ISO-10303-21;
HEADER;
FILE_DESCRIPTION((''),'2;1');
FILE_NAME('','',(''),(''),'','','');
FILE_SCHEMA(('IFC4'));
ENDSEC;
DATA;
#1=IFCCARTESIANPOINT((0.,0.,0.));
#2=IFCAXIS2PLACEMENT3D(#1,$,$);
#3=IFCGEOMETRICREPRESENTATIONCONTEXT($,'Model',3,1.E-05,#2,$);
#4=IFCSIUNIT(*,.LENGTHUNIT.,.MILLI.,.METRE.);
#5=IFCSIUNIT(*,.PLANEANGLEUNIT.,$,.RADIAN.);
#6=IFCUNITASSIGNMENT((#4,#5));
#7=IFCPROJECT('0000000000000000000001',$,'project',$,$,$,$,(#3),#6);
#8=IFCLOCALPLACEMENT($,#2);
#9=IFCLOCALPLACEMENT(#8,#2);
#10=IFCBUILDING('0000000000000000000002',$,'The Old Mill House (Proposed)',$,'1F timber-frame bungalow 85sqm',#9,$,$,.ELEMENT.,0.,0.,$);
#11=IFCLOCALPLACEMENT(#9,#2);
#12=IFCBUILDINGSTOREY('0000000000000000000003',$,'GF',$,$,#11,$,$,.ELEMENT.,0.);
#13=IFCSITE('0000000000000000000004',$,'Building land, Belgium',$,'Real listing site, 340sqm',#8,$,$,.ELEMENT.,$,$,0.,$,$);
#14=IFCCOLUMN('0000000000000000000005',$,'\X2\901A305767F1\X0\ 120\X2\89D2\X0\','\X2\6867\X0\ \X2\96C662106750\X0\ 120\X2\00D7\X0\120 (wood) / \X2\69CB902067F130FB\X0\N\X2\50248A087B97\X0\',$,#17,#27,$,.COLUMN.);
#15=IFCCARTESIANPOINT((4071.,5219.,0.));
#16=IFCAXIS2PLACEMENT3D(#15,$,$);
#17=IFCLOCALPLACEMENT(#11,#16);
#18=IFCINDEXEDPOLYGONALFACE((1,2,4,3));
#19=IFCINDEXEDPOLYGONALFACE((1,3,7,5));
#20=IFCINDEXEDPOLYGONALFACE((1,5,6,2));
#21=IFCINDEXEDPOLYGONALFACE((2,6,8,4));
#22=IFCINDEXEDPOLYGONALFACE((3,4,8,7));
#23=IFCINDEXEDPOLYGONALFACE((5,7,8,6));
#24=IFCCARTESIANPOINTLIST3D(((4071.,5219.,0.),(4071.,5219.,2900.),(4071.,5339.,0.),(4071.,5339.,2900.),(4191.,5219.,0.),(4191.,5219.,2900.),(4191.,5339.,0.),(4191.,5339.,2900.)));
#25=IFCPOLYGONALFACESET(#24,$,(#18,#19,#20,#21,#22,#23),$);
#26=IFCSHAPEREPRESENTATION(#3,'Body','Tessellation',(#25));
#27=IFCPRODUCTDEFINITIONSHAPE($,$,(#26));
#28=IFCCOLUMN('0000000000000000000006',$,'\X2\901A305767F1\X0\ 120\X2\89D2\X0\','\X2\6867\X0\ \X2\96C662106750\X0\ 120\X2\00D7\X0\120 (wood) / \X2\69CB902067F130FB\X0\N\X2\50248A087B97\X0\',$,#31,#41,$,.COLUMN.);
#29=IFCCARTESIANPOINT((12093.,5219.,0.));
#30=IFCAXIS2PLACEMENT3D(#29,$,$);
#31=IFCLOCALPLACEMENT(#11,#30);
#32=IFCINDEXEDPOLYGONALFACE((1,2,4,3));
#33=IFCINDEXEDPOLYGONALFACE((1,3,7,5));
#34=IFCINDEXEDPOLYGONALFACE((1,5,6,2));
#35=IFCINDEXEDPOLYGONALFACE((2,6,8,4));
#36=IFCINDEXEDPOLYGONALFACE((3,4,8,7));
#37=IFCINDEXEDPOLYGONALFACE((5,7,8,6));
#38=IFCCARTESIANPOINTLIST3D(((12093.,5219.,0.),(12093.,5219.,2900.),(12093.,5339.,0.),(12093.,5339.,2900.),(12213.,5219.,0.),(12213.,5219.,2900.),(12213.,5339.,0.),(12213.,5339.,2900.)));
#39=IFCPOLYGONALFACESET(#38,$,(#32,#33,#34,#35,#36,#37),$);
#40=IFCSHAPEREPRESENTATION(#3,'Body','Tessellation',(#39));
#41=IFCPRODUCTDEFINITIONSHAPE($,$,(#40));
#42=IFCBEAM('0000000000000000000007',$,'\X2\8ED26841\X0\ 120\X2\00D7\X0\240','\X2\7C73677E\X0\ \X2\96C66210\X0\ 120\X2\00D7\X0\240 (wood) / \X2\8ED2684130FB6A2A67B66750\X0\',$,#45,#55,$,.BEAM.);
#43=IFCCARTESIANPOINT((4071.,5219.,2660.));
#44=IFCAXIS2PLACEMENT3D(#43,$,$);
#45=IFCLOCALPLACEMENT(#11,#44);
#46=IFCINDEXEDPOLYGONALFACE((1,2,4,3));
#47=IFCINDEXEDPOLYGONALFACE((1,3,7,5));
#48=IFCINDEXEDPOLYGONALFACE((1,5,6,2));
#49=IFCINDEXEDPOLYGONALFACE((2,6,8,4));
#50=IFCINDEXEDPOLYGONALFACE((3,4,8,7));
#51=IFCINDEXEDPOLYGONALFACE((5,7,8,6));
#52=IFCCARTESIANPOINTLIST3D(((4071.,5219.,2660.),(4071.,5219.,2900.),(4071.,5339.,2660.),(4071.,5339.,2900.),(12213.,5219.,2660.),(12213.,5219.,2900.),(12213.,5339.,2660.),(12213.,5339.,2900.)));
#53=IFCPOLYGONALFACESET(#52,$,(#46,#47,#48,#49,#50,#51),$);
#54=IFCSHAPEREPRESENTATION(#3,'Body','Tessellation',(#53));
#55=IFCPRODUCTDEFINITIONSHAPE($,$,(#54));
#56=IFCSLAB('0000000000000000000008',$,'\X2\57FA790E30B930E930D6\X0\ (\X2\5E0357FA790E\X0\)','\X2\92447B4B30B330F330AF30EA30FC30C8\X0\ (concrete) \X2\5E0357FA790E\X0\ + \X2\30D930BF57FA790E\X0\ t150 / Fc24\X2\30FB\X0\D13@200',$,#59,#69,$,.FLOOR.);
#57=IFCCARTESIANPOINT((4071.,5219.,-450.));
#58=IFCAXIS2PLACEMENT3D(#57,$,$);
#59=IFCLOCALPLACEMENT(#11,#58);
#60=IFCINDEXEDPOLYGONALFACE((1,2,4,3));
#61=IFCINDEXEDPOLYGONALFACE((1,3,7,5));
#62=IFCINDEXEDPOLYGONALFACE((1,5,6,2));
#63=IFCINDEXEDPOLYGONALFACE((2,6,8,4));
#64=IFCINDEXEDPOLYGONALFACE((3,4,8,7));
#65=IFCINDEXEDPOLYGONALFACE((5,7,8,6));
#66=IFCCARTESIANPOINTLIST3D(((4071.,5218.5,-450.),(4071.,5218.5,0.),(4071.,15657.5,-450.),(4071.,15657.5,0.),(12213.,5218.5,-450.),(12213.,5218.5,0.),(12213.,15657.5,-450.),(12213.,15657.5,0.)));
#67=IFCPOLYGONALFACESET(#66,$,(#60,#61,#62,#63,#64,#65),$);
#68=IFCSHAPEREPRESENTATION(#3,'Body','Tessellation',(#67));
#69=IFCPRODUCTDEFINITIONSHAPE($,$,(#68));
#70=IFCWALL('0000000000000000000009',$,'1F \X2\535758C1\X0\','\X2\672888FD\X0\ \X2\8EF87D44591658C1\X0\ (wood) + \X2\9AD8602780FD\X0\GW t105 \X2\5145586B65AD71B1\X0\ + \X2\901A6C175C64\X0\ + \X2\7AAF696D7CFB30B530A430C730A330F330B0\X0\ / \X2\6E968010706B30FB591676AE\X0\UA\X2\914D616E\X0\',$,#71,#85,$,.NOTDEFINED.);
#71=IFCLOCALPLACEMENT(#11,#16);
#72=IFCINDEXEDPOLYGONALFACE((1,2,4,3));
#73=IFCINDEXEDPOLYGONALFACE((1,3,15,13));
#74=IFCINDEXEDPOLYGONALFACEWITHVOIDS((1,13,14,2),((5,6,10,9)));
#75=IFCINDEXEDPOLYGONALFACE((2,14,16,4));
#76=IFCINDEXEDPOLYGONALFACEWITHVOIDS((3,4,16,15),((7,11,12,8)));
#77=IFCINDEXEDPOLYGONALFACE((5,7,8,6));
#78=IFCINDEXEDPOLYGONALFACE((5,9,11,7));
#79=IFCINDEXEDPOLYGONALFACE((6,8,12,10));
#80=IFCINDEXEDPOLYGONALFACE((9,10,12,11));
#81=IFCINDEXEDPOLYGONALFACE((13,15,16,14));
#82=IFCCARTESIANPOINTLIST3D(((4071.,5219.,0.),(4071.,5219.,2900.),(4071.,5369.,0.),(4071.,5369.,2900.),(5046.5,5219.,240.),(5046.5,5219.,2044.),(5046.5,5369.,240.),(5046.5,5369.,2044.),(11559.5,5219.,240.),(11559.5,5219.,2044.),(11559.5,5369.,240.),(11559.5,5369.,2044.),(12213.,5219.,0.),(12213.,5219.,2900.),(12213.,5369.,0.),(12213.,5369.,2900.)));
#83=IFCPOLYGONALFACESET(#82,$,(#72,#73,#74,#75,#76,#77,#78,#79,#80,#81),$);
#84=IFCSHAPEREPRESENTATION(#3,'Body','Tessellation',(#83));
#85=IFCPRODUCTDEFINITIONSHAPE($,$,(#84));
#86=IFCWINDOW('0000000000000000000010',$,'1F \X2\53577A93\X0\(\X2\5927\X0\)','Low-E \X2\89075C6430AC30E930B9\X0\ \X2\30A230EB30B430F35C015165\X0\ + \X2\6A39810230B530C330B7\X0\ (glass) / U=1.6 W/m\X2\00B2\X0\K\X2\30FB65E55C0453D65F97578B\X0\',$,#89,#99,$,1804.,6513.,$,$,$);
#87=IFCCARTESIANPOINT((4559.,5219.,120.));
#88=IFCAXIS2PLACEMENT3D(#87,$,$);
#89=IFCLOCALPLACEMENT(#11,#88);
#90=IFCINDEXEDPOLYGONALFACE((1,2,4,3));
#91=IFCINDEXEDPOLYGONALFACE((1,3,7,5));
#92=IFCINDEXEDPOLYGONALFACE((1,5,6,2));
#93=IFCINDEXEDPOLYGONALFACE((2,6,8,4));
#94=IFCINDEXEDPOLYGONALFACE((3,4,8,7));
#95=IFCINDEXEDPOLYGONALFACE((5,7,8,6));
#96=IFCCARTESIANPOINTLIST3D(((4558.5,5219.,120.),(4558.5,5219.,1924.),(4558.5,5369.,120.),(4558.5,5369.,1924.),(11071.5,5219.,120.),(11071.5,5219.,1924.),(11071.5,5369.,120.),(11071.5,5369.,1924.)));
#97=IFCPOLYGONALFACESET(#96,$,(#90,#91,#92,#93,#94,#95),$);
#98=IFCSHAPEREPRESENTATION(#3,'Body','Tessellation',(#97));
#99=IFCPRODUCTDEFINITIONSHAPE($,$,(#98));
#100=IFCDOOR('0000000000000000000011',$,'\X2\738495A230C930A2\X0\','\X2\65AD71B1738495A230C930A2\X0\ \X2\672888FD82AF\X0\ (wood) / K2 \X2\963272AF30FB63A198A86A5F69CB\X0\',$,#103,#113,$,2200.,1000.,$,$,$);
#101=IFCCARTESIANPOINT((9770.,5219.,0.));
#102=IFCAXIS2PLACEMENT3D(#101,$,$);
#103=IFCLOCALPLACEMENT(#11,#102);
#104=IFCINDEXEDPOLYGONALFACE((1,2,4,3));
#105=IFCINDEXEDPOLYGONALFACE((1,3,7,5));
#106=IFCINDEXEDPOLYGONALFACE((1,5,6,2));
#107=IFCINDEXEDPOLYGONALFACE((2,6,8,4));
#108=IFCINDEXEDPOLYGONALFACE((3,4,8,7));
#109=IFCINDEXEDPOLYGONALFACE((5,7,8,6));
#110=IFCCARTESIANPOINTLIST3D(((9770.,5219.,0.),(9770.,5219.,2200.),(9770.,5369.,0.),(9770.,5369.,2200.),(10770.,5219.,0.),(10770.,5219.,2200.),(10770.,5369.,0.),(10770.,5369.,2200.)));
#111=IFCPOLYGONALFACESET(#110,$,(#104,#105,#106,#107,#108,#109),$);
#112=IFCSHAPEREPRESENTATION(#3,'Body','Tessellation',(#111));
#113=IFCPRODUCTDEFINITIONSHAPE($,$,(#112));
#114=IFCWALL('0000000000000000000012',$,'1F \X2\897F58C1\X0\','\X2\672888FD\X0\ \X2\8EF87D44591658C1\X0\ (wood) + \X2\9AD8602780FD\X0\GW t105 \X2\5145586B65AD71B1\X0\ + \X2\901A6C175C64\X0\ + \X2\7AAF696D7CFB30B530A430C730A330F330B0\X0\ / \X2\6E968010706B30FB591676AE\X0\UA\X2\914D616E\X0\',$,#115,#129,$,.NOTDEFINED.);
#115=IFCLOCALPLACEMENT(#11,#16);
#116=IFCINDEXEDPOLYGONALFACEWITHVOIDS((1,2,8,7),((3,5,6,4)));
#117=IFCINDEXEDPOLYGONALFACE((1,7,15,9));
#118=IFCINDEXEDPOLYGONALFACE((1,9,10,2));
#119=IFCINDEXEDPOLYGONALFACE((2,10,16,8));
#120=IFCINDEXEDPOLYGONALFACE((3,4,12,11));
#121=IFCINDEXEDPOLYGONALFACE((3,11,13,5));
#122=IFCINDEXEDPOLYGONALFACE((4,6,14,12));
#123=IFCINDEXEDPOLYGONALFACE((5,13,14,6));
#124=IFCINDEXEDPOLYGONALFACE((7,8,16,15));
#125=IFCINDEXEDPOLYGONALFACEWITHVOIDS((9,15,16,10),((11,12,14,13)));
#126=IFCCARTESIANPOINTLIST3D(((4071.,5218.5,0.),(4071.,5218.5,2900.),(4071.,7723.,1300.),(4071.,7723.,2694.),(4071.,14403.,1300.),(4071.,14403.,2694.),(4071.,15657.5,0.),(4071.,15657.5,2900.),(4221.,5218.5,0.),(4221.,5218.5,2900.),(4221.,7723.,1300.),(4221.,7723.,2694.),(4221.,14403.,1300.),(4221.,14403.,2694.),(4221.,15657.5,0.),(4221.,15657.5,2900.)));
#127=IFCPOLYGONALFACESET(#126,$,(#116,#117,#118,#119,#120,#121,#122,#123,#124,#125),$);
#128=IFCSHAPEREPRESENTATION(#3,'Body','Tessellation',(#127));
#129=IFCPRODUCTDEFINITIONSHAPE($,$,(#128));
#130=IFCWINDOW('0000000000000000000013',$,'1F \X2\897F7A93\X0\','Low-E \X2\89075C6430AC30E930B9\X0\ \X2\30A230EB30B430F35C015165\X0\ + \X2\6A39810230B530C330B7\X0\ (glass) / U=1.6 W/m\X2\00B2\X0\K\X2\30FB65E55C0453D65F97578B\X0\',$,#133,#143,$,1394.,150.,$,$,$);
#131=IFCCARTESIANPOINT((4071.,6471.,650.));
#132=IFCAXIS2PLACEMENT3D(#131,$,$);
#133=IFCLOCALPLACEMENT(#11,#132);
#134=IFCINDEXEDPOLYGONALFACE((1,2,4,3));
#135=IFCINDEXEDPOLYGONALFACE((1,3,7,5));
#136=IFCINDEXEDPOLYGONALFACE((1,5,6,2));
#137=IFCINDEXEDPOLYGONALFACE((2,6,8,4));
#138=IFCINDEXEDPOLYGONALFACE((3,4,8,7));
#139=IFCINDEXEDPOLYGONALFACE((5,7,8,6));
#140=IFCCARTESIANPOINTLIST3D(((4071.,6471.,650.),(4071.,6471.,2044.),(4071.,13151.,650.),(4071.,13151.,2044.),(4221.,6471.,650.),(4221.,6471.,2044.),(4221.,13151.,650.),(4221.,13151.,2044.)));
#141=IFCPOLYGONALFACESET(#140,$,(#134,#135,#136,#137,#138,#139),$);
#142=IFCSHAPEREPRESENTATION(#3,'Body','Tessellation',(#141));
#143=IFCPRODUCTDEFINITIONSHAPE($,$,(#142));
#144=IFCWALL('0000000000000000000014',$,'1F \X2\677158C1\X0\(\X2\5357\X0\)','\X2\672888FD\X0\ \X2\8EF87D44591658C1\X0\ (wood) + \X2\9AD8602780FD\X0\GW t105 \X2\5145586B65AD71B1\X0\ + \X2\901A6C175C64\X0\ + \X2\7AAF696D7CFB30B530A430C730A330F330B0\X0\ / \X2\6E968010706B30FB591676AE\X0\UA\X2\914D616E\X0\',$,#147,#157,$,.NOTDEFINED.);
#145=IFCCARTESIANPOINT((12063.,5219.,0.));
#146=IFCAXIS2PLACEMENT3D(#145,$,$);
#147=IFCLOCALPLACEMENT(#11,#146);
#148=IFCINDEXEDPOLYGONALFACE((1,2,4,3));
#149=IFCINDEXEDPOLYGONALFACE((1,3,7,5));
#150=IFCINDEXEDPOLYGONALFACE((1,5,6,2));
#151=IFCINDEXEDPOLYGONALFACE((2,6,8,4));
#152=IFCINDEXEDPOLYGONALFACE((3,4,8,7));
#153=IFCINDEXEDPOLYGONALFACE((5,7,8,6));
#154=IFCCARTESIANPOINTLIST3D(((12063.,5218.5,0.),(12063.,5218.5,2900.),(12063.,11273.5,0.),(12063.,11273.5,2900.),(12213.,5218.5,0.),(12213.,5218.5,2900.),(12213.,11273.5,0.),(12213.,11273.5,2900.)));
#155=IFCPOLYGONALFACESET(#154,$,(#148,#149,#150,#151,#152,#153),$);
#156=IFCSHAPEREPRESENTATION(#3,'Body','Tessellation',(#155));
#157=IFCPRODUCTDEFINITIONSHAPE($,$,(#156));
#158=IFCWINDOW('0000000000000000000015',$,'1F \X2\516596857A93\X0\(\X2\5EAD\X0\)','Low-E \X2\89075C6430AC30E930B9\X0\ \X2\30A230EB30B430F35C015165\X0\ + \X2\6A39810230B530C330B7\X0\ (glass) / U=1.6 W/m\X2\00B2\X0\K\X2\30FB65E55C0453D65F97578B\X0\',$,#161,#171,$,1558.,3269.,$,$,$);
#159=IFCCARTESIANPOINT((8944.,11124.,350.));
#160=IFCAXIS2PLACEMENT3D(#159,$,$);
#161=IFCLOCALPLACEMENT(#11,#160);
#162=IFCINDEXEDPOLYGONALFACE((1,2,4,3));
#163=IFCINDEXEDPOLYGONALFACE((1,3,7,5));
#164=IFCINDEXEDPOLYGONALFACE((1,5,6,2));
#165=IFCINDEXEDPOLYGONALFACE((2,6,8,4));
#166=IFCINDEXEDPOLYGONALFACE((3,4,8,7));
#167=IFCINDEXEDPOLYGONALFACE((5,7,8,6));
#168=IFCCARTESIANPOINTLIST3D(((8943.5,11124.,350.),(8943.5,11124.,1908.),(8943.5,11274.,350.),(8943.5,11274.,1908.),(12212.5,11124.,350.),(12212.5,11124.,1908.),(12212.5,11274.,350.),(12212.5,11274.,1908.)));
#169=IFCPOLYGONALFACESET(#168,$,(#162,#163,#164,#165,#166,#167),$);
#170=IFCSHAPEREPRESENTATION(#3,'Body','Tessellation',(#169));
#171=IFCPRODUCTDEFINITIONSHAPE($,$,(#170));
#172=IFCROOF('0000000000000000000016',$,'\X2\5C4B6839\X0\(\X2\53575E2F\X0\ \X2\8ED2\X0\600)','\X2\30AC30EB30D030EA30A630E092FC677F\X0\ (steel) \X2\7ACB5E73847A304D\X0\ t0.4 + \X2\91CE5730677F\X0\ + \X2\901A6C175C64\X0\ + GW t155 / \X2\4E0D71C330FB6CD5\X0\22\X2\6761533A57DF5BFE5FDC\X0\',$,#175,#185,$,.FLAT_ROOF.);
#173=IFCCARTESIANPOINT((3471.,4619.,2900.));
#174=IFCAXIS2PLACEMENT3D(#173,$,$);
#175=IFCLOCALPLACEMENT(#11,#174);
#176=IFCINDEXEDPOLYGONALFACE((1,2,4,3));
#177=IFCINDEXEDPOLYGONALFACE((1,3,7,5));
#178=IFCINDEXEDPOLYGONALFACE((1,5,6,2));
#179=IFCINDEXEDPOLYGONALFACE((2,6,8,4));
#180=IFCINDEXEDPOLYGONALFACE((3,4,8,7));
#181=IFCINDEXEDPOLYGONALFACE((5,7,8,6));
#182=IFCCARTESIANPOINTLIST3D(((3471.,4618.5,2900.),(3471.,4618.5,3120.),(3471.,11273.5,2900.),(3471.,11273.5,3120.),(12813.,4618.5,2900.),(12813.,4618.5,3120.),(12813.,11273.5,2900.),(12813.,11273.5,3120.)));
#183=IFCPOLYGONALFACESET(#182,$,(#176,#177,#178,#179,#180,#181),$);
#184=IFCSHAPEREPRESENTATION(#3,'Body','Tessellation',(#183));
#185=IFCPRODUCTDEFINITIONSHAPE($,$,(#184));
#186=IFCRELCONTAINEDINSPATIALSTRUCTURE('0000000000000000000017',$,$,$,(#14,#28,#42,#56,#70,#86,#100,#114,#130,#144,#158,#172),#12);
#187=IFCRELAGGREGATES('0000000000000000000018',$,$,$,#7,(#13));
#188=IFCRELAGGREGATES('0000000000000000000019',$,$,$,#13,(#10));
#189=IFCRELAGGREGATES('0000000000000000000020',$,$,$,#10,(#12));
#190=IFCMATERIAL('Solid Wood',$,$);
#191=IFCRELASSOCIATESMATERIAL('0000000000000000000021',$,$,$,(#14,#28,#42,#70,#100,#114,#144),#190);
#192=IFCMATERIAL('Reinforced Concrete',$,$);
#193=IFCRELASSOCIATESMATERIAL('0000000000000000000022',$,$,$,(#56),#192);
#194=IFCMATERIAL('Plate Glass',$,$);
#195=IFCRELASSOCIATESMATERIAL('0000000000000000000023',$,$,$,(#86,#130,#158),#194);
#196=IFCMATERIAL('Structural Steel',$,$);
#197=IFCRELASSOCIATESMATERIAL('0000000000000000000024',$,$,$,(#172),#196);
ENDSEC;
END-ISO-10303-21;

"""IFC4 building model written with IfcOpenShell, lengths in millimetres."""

from ifc_helpers import new_model, si_unit, frame, frame_2d, origin, place, context, project, spatial, rectangle, extrude, material, element, fill, save


model = new_model("IFC4")

# Units and contexts
model_context = context("Model", 3, precision=1e-05, world=origin())
ifc_project = project(units=[si_unit("LENGTHUNIT", "METRE", prefix="MILLI"), si_unit("PLANEANGLEUNIT", "RADIAN")], contexts=[model_context])

# Site, building, storey
site_placement = place(None, origin())
site = spatial("IfcSite", under=ifc_project, at=site_placement, Name="Building land, Belgium", ObjectType="Real listing site, 340sqm", CompositionType="ELEMENT", RefElevation=0.0)
building_placement = place(site_placement, origin())
building = spatial("IfcBuilding", under=site, at=building_placement, Name="The Old Mill House (Proposed)", ObjectType="1F timber-frame bungalow 85sqm", CompositionType="ELEMENT", ElevationOfRefHeight=0.0, ElevationOfTerrain=0.0)
storey_placement = place(building_placement, origin())
storey = spatial("IfcBuildingStorey", under=building, at=storey_placement, Name="GF", CompositionType="ELEMENT", Elevation=0.0)

# Columns
ifc_material_1 = material(Name="Solid Wood")
column_1_placement = place(storey_placement, frame((4071.0, 5219.0, 0.0)))
element("IfcColumn", 1, at=column_1_placement, inside=storey, material=ifc_material_1, Name="通し柱 120角", Description="桧 集成材 120×120 (wood) / 構造柱・N値計算", PredefinedType="COLUMN", context=model_context, shape_type="SweptSolid", body=[
    extrude(rectangle(XDim=120.0, YDim=120.0, at=frame_2d((60.0, 60.0))), frame((4071.0, 5219.0, 0.0)), (0.0, 0.0, 1.0), 2900.0),
])
column_2_placement = place(storey_placement, frame((12093.0, 5219.0, 0.0)))
element("IfcColumn", 2, at=column_2_placement, inside=storey, material=ifc_material_1, Name="通し柱 120角", Description="桧 集成材 120×120 (wood) / 構造柱・N値計算", PredefinedType="COLUMN", context=model_context, shape_type="SweptSolid", body=[
    extrude(rectangle(XDim=120.0, YDim=120.0, at=frame_2d((60.0, 60.0))), frame((12093.0, 5219.0, 0.0)), (0.0, 0.0, 1.0), 2900.0),
])

# Beam
beam_1_placement = place(storey_placement, frame((4071.0, 5219.0, 2660.0)))
element("IfcBeam", 3, at=beam_1_placement, inside=storey, material=ifc_material_1, Name="軒桁 120×240", Description="米松 集成 120×240 (wood) / 軒桁・横架材", PredefinedType="BEAM", context=model_context, shape_type="SweptSolid", body=[
    extrude(rectangle(XDim=8142.0, YDim=120.0, at=frame_2d((4071.0, 60.0))), frame((4071.0, 5219.0, 2660.0)), (0.0, 0.0, 1.0), 240.0),
])

# Slab
ifc_material_2 = material(Name="Reinforced Concrete")
slab_1_placement = place(storey_placement, frame((4071.0, 5219.0, -450.0)))
element("IfcSlab", 4, at=slab_1_placement, inside=storey, material=ifc_material_2, Name="基礎スラブ (布基礎)", Description="鉄筋コンクリート (concrete) 布基礎 + ベタ基礎 t150 / Fc24・D13@200", PredefinedType="FLOOR", context=model_context, shape_type="SweptSolid", body=[
    extrude(rectangle(XDim=8142.0, YDim=10439.0, at=frame_2d((4071.0, 5219.0))), frame((4071.0, 5219.0, -450.0)), (0.0, 0.0, 1.0), 450.0),
])

# Wall, openings, window, door
wall_1_placement = place(storey_placement, frame((4071.0, 5219.0, 0.0)))
wall_1 = element("IfcWall", 5, at=wall_1_placement, inside=storey, material=ifc_material_1, Name="1F 南壁", Description="木製 軸組外壁 (wood) + 高性能GW t105 充填断熱 + 通気層 + 窯業系サイディング / 準耐火・外皮UA配慮", PredefinedType="NOTDEFINED", context=model_context, shape_type="SweptSolid", body=[
    extrude(rectangle(XDim=8142.0, YDim=150.0, at=frame_2d((4071.0, 75.0))), frame((4071.0, 5219.0, 0.0)), (0.0, 0.0, 1.0), 2900.0),
])
opening_1_placement = place(storey_placement, frame((4559.0, 5219.0, 120.0)))
opening_1 = element("IfcOpeningElement", 6, at=opening_1_placement, cuts=wall_1, PredefinedType="NOTDEFINED", context=model_context, shape_type="SweptSolid", body=[
    extrude(rectangle(XDim=6513.0, YDim=150.0, at=frame_2d((3256.0, 75.0))), frame((4559.0, 5219.0, 120.0)), (0.0, 0.0, 1.0), 1804.0),
])
opening_2_placement = place(storey_placement, frame((9770.0, 5219.0, 0.0)))
opening_2 = element("IfcOpeningElement", 7, at=opening_2_placement, cuts=wall_1, PredefinedType="NOTDEFINED", context=model_context, shape_type="SweptSolid", body=[
    extrude(rectangle(XDim=1000.0, YDim=150.0, at=frame_2d((500.0, 75.0))), frame((9770.0, 5219.0, 0.0)), (0.0, 0.0, 1.0), 2200.0),
])
ifc_material_3 = material(Name="Plate Glass")
window_1_placement = place(storey_placement, frame((4559.0, 5219.0, 120.0)))
window_1 = element("IfcWindow", 8, at=window_1_placement, inside=storey, material=ifc_material_3, Name="1F 南窓(大)", Description="Low-E 複層ガラス アルゴン封入 + 樹脂サッシ (glass) / U=1.6 W/m²K・日射取得型", OverallHeight=1804.0, OverallWidth=6513.0, context=model_context, shape_type="SweptSolid", body=[
    extrude(rectangle(XDim=6513.0, YDim=150.0, at=frame_2d((3256.0, 75.0))), frame((4559.0, 5219.0, 120.0)), (0.0, 0.0, 1.0), 1804.0),
])
fill(opening_1, window_1)
door_1_placement = place(storey_placement, frame((9770.0, 5219.0, 0.0)))
door_1 = element("IfcDoor", 9, at=door_1_placement, inside=storey, material=ifc_material_1, Name="玄関ドア", Description="断熱玄関ドア 木製芯 (wood) / K2 防犯・採風機構", OverallHeight=2200.0, OverallWidth=1000.0, context=model_context, shape_type="SweptSolid", body=[
    extrude(rectangle(XDim=1000.0, YDim=150.0, at=frame_2d((500.0, 75.0))), frame((9770.0, 5219.0, 0.0)), (0.0, 0.0, 1.0), 2200.0),
])
fill(opening_2, door_1)

# Walls, openings, windows
wall_2_placement = place(storey_placement, frame((4071.0, 5219.0, 0.0)))
wall_2 = element("IfcWall", 10, at=wall_2_placement, inside=storey, material=ifc_material_1, Name="1F 西壁", Description="木製 軸組外壁 (wood) + 高性能GW t105 充填断熱 + 通気層 + 窯業系サイディング / 準耐火・外皮UA配慮", PredefinedType="NOTDEFINED", context=model_context, shape_type="SweptSolid", body=[
    extrude(rectangle(XDim=150.0, YDim=10439.0, at=frame_2d((75.0, 5219.0))), frame((4071.0, 5219.0, 0.0)), (0.0, 0.0, 1.0), 2900.0),
])
opening_3_placement = place(storey_placement, frame((4071.0, 6471.0, 650.0)))
opening_3 = element("IfcOpeningElement", 11, at=opening_3_placement, cuts=wall_2, PredefinedType="NOTDEFINED", context=model_context, shape_type="SweptSolid", body=[
    extrude(rectangle(XDim=150.0, YDim=6680.0, at=frame_2d((75.0, 3340.0))), frame((4071.0, 6471.0, 650.0)), (0.0, 0.0, 1.0), 1394.0),
])
window_2_placement = place(storey_placement, frame((4071.0, 6471.0, 650.0)))
window_2 = element("IfcWindow", 12, at=window_2_placement, inside=storey, material=ifc_material_3, Name="1F 西窓", Description="Low-E 複層ガラス アルゴン封入 + 樹脂サッシ (glass) / U=1.6 W/m²K・日射取得型", OverallHeight=1394.0, OverallWidth=150.0, context=model_context, shape_type="SweptSolid", body=[
    extrude(rectangle(XDim=150.0, YDim=6680.0, at=frame_2d((75.0, 3340.0))), frame((4071.0, 6471.0, 650.0)), (0.0, 0.0, 1.0), 1394.0),
])
fill(opening_3, window_2)
wall_3_placement = place(storey_placement, frame((12063.0, 5219.0, 0.0)))
wall_3 = element("IfcWall", 13, at=wall_3_placement, inside=storey, material=ifc_material_1, Name="1F 東壁(南)", Description="木製 軸組外壁 (wood) + 高性能GW t105 充填断熱 + 通気層 + 窯業系サイディング / 準耐火・外皮UA配慮", PredefinedType="NOTDEFINED", context=model_context, shape_type="SweptSolid", body=[
    extrude(rectangle(XDim=150.0, YDim=6055.0, at=frame_2d((75.0, 3027.0))), frame((12063.0, 5219.0, 0.0)), (0.0, 0.0, 1.0), 2900.0),
])
opening_4_placement = place(storey_placement, frame((8944.0, 11124.0, 350.0)))
opening_4 = element("IfcOpeningElement", 14, at=opening_4_placement, cuts=wall_3, PredefinedType="NOTDEFINED", context=model_context, shape_type="SweptSolid", body=[
    extrude(rectangle(XDim=3269.0, YDim=150.0, at=frame_2d((1634.0, 75.0))), frame((8944.0, 11124.0, 350.0)), (0.0, 0.0, 1.0), 1558.0),
])
window_3_placement = place(storey_placement, frame((8944.0, 11124.0, 350.0)))
window_3 = element("IfcWindow", 15, at=window_3_placement, inside=storey, material=ifc_material_3, Name="1F 入隅窓(庭)", Description="Low-E 複層ガラス アルゴン封入 + 樹脂サッシ (glass) / U=1.6 W/m²K・日射取得型", OverallHeight=1558.0, OverallWidth=3269.0, context=model_context, shape_type="SweptSolid", body=[
    extrude(rectangle(XDim=3269.0, YDim=150.0, at=frame_2d((1634.0, 75.0))), frame((8944.0, 11124.0, 350.0)), (0.0, 0.0, 1.0), 1558.0),
])
fill(opening_4, window_3)

# Roof
ifc_material_4 = material(Name="Structural Steel")
roof_placement = place(storey_placement, frame((3471.0, 4619.0, 2900.0)))
element("IfcRoof", 16, at=roof_placement, inside=storey, material=ifc_material_4, Name="屋根(南帯 軒600)", Description="ガルバリウム鋼板 (steel) 立平葺き t0.4 + 野地板 + 通気層 + GW t155 / 不燃・法22条区域対応", PredefinedType="FLAT_ROOF", context=model_context, shape_type="SweptSolid", body=[
    extrude(rectangle(XDim=9342.0, YDim=6655.0, at=frame_2d((4671.0, 3327.0))), frame((3471.0, 4619.0, 2900.0)), (0.0, 0.0, 1.0), 220.0),
])

save(model, "model.ifc")
